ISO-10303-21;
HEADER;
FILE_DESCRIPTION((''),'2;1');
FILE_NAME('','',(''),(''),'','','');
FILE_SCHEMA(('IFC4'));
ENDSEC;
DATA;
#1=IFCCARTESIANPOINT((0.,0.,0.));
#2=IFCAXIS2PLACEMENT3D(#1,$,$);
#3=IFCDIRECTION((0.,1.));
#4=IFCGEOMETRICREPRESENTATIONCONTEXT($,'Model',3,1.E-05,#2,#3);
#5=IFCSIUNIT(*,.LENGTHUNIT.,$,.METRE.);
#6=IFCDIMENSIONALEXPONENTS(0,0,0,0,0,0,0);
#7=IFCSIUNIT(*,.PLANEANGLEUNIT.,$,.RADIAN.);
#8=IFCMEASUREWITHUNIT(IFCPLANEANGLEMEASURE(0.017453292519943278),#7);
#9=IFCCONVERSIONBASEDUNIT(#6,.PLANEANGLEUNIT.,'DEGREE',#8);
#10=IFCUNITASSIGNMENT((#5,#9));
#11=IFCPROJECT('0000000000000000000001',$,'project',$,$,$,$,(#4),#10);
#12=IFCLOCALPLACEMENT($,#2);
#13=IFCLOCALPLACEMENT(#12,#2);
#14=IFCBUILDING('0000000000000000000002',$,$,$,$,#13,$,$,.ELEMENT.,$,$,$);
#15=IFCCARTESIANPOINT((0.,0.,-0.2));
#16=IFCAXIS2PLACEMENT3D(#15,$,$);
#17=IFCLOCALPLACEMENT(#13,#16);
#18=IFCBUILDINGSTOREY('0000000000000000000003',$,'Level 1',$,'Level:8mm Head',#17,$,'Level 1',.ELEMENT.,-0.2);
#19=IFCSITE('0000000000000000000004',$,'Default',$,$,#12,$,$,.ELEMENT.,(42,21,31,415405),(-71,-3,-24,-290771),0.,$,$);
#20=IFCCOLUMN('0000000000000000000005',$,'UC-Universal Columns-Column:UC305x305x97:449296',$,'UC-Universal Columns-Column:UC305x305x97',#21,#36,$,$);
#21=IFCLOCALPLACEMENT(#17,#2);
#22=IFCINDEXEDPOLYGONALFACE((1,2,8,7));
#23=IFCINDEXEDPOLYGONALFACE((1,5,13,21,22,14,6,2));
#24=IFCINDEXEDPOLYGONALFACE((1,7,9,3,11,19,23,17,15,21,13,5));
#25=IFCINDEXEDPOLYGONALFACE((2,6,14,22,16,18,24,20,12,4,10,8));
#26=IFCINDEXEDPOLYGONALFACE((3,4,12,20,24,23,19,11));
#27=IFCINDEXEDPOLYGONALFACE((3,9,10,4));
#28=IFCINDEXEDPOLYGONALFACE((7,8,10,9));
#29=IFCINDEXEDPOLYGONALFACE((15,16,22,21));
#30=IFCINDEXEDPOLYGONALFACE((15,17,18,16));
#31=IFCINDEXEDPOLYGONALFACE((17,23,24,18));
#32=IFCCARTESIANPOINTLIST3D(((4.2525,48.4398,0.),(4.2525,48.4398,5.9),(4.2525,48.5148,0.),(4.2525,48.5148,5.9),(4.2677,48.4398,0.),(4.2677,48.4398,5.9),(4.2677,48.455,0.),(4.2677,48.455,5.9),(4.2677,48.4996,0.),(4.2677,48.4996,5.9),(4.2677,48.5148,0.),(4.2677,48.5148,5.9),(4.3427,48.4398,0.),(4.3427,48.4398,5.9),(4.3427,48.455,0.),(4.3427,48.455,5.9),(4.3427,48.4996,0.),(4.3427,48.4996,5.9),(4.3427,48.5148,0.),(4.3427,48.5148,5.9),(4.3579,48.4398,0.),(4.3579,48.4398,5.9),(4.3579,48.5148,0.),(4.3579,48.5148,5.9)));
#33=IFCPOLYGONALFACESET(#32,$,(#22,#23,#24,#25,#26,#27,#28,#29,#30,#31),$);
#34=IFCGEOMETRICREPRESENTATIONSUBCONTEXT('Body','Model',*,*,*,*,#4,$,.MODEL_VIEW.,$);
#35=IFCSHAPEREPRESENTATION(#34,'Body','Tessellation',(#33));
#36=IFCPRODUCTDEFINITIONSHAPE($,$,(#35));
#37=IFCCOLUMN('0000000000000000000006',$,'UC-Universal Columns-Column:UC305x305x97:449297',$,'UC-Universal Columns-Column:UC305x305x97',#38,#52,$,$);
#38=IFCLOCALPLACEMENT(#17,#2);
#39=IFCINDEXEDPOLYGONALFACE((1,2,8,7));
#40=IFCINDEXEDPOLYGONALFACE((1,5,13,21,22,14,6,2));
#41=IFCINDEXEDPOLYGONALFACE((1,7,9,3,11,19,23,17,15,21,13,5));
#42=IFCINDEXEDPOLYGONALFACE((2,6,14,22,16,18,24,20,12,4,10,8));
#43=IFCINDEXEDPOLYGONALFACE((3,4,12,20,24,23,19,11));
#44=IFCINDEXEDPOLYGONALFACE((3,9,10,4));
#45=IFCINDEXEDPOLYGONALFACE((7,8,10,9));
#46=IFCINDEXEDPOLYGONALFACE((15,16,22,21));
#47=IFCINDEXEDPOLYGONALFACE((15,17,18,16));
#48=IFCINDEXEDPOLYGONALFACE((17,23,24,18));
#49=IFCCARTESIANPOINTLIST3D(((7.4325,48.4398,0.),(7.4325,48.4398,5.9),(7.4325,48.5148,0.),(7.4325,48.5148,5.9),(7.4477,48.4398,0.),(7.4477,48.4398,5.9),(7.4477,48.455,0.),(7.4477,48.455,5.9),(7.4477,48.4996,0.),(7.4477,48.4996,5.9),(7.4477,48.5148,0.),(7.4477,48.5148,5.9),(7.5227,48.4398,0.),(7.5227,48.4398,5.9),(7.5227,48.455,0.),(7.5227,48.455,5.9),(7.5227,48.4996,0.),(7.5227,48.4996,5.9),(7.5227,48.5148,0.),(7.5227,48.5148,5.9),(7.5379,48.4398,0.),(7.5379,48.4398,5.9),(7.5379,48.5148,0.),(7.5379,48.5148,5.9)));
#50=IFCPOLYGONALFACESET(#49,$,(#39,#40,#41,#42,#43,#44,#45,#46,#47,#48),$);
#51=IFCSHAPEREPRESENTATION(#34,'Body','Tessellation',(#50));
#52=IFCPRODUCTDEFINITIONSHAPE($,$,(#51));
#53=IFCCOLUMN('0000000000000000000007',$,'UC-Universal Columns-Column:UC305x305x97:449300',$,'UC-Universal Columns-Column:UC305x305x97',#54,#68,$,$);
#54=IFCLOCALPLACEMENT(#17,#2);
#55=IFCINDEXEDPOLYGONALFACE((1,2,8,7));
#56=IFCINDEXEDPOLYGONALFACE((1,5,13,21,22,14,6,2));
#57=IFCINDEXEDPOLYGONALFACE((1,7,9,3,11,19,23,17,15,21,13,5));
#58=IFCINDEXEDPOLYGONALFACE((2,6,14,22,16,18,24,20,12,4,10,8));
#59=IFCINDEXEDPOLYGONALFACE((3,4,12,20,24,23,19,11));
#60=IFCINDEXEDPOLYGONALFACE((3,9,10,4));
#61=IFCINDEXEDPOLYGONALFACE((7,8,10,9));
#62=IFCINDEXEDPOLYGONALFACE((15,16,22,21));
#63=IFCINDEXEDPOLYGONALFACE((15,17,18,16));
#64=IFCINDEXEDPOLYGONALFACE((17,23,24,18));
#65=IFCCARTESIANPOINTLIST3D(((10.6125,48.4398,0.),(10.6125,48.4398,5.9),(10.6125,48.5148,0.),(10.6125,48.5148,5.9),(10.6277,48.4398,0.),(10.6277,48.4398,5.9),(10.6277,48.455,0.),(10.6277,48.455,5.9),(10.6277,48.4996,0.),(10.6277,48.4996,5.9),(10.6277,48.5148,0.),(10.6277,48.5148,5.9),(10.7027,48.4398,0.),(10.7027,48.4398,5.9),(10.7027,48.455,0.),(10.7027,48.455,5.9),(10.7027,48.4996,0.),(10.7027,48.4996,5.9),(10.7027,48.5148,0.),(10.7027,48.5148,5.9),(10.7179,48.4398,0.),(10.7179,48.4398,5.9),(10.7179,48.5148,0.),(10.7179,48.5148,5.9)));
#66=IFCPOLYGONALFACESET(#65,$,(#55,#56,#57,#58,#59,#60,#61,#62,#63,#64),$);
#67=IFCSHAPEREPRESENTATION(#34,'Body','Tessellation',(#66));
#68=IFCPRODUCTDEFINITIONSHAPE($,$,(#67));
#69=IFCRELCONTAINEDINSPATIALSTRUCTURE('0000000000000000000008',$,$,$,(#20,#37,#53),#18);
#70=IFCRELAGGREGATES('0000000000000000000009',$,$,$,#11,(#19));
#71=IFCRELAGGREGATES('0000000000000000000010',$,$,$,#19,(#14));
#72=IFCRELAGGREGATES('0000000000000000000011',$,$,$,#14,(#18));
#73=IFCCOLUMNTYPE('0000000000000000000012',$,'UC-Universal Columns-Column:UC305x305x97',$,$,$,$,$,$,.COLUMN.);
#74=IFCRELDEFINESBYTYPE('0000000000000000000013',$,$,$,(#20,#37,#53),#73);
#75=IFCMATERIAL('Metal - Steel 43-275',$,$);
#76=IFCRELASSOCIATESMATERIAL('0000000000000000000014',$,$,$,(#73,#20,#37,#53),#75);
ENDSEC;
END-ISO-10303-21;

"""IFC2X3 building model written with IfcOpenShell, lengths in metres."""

from ifc_helpers import new_model, entity, si_unit, converted_unit, direction, frame, frame_2d, origin, place, context, subcontext, project, spatial, polyline, circle_curve, parameter, trimmed, segment, composite_curve, outline, extrude, source, transform, mapped, material, type_object, type_shapes, element, save


model = new_model("IFC2X3")

# Units and contexts
model_context = context("Model", 3, precision=1e-05, world=origin(), true_north=direction((0.0, 1.0)))
body_context = subcontext(model_context, "Body", "Model", "MODEL_VIEW")
ifc_project = project(units=[si_unit("LENGTHUNIT", "METRE"), converted_unit("PLANEANGLEUNIT", "DEGREE", entity("IfcPlaneAngleMeasure", 0.017453292519943278), si_unit("PLANEANGLEUNIT", "RADIAN"), dimensions=[0, 0, 0, 0, 0, 0, 0])], contexts=[model_context])

# Site, building, storey
site_placement = place(None, origin())
site = spatial("IfcSite", under=ifc_project, at=site_placement, Name="Default", CompositionType="ELEMENT", RefLatitude=(42, 21, 31, 415405), RefLongitude=(-71, -3, -24, -290771), RefElevation=0.0)
building_placement = place(site_placement, origin())
building = spatial("IfcBuilding", under=site, at=building_placement, CompositionType="ELEMENT")
storey_placement = place(building_placement, frame((0.0, 0.0, -0.2)))
storey = spatial("IfcBuildingStorey", under=building, at=storey_placement, Name="Level 1", ObjectType="Level:8mm Head", LongName="Level 1", CompositionType="ELEMENT", Elevation=-0.2)

# Columns
ifc_material = material(Name="Metal - Steel 43-275")
column_type = type_object("IfcColumnType", Name="UC-Universal Columns-Column:UC305x305x97", PredefinedType="COLUMN", material=ifc_material)
shared_shape = source(origin(), body_context, "Body", "SweptSolid", [
    extrude(outline(composite_curve([segment(polyline([(-0.0375, -0.0375), (0.0375, -0.0375)]), True, "CONTINUOUS"), segment(polyline([(0.0375, -0.0375), (0.0527, -0.0375)]), True, "CONTINUOUS"), segment(trimmed(circle_curve(frame_2d((0.0527, -0.0223), x_axis=(-1.0, 0.0)), 0.0152), [parameter(0.0)], [parameter(90.0)], True, "PARAMETER"), False, "CONTINUOUS"), segment(polyline([(0.0375, -0.0223), (0.0375, 0.0223)]), True, "CONTINUOUS"), segment(trimmed(circle_curve(frame_2d((0.0527, 0.0223), x_axis=(-1.0, 0.0)), 0.0152), [parameter(270.0)], [parameter(0.0)], True, "PARAMETER"), False, "CONTINUOUS"), segment(polyline([(0.0527, 0.0375), (0.0375, 0.0375)]), True, "CONTINUOUS"), segment(polyline([(0.0375, 0.0375), (-0.0375, 0.0375)]), True, "CONTINUOUS"), segment(polyline([(-0.0375, 0.0375), (-0.0527, 0.0375)]), True, "CONTINUOUS"), segment(trimmed(circle_curve(frame_2d((-0.0527, 0.0223), x_axis=(-1.0, 0.0)), 0.0152), [parameter(180.0)], [parameter(270.0)], True, "PARAMETER"), False, "CONTINUOUS"), segment(polyline([(-0.0375, 0.0223), (-0.0375, -0.0223)]), True, "CONTINUOUS"), segment(trimmed(circle_curve(frame_2d((-0.0527, -0.0223), x_axis=(-1.0, 0.0)), 0.0152), [parameter(90.0)], [parameter(180.0)], True, "PARAMETER"), False, "CONTINUOUS"), segment(polyline([(-0.0527, -0.0375), (-0.0375, -0.0375)]), True, "CONTINUOUS")], self_intersect=False)), frame((0.0, 0.0, -0.2), z_axis=(0.0, 0.0, 1.0), x_axis=(-1.0, 0.0, 0.0)), (0.0, 0.0, 1.0), 5.9),
])
type_shapes(column_type, [shared_shape])
for number, where, z_axis, x_axis, name in (
    (1, (4.3052, 48.4773, 0.2), (0.0, 0.0, 1.0), (-1.0, 0.0, 0.0), "UC-Universal Columns-Column:UC305x305x97:449296"),
    (2, (7.4852, 48.4773, 0.2), (0.0, 0.0, 1.0), (-1.0, 0.0, 0.0), "UC-Universal Columns-Column:UC305x305x97:449297"),
    (3, (10.6652, 48.4773, 0.2), (0.0, 0.0, 1.0), (-1.0, 0.0, 0.0), "UC-Universal Columns-Column:UC305x305x97:449300"),
):
    element("IfcColumn", number, at=place(storey_placement, frame(where, z_axis=z_axis, x_axis=x_axis)), inside=storey, type_object=column_type, material=ifc_material, Name=name, ObjectType="UC-Universal Columns-Column:UC305x305x97", context=body_context, shape_type="MappedRepresentation", body=[
        mapped(shared_shape, transform((0.0, 0.0, 0.0), scale=1.0)),
    ])

save(model, "model.ifc")
